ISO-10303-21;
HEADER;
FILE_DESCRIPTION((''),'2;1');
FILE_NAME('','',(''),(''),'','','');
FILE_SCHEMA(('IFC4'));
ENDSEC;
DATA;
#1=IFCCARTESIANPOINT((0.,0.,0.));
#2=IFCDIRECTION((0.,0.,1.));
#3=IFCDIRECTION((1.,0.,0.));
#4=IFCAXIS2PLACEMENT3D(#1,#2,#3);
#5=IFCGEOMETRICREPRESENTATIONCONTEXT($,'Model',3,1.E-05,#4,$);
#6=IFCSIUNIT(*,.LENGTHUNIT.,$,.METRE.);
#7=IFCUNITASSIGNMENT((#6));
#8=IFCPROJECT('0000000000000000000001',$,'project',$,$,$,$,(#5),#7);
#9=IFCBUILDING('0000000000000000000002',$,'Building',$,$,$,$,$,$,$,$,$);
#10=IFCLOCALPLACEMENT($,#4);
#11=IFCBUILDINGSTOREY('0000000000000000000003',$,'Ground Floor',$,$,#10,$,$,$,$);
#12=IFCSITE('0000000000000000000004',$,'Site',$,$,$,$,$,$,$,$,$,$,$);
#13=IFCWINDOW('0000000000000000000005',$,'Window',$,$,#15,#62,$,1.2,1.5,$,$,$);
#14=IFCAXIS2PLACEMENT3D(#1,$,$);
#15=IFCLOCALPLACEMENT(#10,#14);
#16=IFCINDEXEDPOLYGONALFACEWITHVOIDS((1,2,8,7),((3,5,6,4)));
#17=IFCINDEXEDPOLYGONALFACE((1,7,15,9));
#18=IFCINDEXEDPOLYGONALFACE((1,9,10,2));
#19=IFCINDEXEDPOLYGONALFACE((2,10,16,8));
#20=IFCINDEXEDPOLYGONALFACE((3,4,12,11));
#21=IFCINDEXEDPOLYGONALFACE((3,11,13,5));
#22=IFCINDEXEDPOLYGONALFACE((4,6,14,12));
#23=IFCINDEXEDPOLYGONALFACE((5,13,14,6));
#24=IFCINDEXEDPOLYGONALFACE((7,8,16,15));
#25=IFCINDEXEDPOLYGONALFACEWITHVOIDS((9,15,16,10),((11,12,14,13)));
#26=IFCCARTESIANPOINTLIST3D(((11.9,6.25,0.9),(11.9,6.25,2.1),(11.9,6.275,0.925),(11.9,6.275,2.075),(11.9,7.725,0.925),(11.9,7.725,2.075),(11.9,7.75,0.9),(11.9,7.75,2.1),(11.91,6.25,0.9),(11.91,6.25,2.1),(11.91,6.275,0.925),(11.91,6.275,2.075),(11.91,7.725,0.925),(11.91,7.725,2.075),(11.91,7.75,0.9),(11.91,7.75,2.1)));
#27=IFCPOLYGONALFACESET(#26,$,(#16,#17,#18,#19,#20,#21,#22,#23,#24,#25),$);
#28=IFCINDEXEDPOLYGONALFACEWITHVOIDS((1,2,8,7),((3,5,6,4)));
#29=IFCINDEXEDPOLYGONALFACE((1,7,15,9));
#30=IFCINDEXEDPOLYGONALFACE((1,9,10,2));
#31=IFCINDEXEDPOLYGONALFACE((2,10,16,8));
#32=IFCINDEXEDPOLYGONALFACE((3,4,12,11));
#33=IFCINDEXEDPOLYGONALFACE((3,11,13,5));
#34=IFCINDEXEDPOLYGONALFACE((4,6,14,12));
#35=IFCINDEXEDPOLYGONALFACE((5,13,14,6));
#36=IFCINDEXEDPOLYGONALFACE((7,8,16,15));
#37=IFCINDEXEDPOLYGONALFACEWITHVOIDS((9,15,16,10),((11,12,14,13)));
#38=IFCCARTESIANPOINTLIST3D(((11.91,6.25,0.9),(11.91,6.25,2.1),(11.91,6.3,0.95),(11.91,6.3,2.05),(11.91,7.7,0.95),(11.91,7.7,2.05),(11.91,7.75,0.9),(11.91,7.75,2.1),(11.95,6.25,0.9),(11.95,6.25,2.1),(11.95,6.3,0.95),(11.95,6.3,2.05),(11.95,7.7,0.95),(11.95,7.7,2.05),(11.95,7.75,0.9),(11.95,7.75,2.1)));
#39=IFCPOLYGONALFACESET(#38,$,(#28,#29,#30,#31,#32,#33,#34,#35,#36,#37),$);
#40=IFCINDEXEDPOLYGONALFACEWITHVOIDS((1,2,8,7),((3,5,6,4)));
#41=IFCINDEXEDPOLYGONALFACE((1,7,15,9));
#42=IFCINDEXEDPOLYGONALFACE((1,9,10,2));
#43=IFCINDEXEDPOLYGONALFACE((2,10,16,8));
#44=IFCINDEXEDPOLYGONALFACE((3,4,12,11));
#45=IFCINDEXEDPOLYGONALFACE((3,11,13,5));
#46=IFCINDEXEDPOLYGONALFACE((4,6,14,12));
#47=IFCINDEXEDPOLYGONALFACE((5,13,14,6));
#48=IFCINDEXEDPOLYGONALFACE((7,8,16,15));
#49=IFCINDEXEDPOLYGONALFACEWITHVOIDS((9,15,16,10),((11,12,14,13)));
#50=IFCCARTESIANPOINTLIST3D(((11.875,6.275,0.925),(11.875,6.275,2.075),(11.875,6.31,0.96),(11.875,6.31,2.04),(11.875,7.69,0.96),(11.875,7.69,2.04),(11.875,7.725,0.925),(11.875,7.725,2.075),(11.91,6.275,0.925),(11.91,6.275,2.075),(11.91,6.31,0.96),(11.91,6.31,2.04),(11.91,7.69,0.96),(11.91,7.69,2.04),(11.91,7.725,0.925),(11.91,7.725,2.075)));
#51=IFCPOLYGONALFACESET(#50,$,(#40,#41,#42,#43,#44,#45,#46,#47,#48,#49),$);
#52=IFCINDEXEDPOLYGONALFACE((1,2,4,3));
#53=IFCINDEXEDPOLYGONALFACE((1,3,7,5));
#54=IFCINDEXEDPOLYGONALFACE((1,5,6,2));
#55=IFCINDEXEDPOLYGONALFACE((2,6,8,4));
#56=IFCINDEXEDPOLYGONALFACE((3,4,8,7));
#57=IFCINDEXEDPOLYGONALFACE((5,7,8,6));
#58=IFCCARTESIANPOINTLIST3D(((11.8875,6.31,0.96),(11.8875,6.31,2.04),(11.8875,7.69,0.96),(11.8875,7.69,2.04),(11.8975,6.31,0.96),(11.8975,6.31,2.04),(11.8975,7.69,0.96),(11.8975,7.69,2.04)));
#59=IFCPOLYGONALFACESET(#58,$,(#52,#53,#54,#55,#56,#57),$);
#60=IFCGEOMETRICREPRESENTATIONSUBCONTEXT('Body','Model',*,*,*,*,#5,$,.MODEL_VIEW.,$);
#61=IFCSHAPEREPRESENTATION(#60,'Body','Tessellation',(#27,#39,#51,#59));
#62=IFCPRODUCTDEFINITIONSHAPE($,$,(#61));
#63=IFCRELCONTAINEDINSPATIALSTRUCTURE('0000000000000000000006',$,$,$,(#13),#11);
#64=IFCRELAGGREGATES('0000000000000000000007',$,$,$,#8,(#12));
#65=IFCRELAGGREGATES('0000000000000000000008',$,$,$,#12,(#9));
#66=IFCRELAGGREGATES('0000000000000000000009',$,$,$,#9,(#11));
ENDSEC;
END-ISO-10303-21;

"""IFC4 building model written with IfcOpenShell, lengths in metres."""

from ifc_helpers import new_model, si_unit, frame, origin_with_axes, place, context, subcontext, project, spatial, line, indexed_curve, outline, extrude, element, save


model = new_model("IFC4")

# Units and contexts
model_context = context("Model", 3, precision=1e-05, world=origin_with_axes())
body_context = subcontext(model_context, "Body", "Model", "MODEL_VIEW")
ifc_project = project(units=[si_unit("LENGTHUNIT", "METRE")], contexts=[model_context])

# Site, building, storey
site = spatial("IfcSite", under=ifc_project, Name="Site")
building = spatial("IfcBuilding", under=site, Name="Building")
storey_placement = place(None, origin_with_axes())
storey = spatial("IfcBuildingStorey", under=building, at=storey_placement, Name="Ground Floor")

# Window
for number, where, z_axis, x_axis, name in (
    (1, (12.0, 6.25, 0.9), (0.0, 0.0, 1.0), (0.0, 1.0, 0.0), "Window"),
):
    element("IfcWindow", number, at=place(storey_placement, frame(where, z_axis=z_axis, x_axis=x_axis)), inside=storey, Name=name, OverallHeight=1.2, OverallWidth=1.5, context=body_context, shape_type="SweptSolid", body=[
        extrude(outline(indexed_curve([(0.0, 0.0), (1.5, 0.0), (1.5, 1.2), (0.0, 1.2)], segments=[line(1, 2, 3, 4, 1)]), holes=[indexed_curve([(0.025, 0.025), (1.475, 0.025), (1.475, 1.175), (0.025, 1.175)], segments=[line(1, 2, 3, 4, 1)])]), frame((0.0, 0.09, 0.0), z_axis=(0.0, -1.0, 0.0), x_axis=(1.0, 0.0, 0.0)), (0.0, 0.0, -1.0), 0.01),
        extrude(outline(indexed_curve([(0.0, 0.0), (1.5, 0.0), (1.5, 1.2), (0.0, 1.2)], segments=[line(1, 2, 3, 4, 1)]), holes=[indexed_curve([(0.05, 0.05), (1.45, 0.05), (1.45, 1.15), (0.05, 1.15)], segments=[line(1, 2, 3, 4, 1)])]), frame((0.0, 0.05, 0.0), z_axis=(0.0, -1.0, 0.0), x_axis=(1.0, 0.0, 0.0)), (0.0, 0.0, -1.0), 0.04),
        extrude(outline(indexed_curve([(0.0, 0.0), (1.45, 0.0), (1.45, 1.15), (0.0, 1.15)], segments=[line(1, 2, 3, 4, 1)]), holes=[indexed_curve([(0.035, 0.035), (1.415, 0.035), (1.415, 1.115), (0.035, 1.115)], segments=[line(1, 2, 3, 4, 1)])]), frame((0.025, 0.09, 0.025), z_axis=(0.0, -1.0, 0.0), x_axis=(1.0, 0.0, 0.0)), (0.0, 0.0, -1.0), 0.035),
        extrude(outline(indexed_curve([(0.035, 0.035), (1.415, 0.035), (1.415, 1.115), (0.035, 1.115)], segments=[line(1, 2, 3, 4, 1)])), frame((0.025, 0.1025, 0.025), z_axis=(0.0, -1.0, 0.0), x_axis=(1.0, 0.0, 0.0)), (0.0, 0.0, -1.0), 0.01),
    ])

save(model, "model.ifc")
